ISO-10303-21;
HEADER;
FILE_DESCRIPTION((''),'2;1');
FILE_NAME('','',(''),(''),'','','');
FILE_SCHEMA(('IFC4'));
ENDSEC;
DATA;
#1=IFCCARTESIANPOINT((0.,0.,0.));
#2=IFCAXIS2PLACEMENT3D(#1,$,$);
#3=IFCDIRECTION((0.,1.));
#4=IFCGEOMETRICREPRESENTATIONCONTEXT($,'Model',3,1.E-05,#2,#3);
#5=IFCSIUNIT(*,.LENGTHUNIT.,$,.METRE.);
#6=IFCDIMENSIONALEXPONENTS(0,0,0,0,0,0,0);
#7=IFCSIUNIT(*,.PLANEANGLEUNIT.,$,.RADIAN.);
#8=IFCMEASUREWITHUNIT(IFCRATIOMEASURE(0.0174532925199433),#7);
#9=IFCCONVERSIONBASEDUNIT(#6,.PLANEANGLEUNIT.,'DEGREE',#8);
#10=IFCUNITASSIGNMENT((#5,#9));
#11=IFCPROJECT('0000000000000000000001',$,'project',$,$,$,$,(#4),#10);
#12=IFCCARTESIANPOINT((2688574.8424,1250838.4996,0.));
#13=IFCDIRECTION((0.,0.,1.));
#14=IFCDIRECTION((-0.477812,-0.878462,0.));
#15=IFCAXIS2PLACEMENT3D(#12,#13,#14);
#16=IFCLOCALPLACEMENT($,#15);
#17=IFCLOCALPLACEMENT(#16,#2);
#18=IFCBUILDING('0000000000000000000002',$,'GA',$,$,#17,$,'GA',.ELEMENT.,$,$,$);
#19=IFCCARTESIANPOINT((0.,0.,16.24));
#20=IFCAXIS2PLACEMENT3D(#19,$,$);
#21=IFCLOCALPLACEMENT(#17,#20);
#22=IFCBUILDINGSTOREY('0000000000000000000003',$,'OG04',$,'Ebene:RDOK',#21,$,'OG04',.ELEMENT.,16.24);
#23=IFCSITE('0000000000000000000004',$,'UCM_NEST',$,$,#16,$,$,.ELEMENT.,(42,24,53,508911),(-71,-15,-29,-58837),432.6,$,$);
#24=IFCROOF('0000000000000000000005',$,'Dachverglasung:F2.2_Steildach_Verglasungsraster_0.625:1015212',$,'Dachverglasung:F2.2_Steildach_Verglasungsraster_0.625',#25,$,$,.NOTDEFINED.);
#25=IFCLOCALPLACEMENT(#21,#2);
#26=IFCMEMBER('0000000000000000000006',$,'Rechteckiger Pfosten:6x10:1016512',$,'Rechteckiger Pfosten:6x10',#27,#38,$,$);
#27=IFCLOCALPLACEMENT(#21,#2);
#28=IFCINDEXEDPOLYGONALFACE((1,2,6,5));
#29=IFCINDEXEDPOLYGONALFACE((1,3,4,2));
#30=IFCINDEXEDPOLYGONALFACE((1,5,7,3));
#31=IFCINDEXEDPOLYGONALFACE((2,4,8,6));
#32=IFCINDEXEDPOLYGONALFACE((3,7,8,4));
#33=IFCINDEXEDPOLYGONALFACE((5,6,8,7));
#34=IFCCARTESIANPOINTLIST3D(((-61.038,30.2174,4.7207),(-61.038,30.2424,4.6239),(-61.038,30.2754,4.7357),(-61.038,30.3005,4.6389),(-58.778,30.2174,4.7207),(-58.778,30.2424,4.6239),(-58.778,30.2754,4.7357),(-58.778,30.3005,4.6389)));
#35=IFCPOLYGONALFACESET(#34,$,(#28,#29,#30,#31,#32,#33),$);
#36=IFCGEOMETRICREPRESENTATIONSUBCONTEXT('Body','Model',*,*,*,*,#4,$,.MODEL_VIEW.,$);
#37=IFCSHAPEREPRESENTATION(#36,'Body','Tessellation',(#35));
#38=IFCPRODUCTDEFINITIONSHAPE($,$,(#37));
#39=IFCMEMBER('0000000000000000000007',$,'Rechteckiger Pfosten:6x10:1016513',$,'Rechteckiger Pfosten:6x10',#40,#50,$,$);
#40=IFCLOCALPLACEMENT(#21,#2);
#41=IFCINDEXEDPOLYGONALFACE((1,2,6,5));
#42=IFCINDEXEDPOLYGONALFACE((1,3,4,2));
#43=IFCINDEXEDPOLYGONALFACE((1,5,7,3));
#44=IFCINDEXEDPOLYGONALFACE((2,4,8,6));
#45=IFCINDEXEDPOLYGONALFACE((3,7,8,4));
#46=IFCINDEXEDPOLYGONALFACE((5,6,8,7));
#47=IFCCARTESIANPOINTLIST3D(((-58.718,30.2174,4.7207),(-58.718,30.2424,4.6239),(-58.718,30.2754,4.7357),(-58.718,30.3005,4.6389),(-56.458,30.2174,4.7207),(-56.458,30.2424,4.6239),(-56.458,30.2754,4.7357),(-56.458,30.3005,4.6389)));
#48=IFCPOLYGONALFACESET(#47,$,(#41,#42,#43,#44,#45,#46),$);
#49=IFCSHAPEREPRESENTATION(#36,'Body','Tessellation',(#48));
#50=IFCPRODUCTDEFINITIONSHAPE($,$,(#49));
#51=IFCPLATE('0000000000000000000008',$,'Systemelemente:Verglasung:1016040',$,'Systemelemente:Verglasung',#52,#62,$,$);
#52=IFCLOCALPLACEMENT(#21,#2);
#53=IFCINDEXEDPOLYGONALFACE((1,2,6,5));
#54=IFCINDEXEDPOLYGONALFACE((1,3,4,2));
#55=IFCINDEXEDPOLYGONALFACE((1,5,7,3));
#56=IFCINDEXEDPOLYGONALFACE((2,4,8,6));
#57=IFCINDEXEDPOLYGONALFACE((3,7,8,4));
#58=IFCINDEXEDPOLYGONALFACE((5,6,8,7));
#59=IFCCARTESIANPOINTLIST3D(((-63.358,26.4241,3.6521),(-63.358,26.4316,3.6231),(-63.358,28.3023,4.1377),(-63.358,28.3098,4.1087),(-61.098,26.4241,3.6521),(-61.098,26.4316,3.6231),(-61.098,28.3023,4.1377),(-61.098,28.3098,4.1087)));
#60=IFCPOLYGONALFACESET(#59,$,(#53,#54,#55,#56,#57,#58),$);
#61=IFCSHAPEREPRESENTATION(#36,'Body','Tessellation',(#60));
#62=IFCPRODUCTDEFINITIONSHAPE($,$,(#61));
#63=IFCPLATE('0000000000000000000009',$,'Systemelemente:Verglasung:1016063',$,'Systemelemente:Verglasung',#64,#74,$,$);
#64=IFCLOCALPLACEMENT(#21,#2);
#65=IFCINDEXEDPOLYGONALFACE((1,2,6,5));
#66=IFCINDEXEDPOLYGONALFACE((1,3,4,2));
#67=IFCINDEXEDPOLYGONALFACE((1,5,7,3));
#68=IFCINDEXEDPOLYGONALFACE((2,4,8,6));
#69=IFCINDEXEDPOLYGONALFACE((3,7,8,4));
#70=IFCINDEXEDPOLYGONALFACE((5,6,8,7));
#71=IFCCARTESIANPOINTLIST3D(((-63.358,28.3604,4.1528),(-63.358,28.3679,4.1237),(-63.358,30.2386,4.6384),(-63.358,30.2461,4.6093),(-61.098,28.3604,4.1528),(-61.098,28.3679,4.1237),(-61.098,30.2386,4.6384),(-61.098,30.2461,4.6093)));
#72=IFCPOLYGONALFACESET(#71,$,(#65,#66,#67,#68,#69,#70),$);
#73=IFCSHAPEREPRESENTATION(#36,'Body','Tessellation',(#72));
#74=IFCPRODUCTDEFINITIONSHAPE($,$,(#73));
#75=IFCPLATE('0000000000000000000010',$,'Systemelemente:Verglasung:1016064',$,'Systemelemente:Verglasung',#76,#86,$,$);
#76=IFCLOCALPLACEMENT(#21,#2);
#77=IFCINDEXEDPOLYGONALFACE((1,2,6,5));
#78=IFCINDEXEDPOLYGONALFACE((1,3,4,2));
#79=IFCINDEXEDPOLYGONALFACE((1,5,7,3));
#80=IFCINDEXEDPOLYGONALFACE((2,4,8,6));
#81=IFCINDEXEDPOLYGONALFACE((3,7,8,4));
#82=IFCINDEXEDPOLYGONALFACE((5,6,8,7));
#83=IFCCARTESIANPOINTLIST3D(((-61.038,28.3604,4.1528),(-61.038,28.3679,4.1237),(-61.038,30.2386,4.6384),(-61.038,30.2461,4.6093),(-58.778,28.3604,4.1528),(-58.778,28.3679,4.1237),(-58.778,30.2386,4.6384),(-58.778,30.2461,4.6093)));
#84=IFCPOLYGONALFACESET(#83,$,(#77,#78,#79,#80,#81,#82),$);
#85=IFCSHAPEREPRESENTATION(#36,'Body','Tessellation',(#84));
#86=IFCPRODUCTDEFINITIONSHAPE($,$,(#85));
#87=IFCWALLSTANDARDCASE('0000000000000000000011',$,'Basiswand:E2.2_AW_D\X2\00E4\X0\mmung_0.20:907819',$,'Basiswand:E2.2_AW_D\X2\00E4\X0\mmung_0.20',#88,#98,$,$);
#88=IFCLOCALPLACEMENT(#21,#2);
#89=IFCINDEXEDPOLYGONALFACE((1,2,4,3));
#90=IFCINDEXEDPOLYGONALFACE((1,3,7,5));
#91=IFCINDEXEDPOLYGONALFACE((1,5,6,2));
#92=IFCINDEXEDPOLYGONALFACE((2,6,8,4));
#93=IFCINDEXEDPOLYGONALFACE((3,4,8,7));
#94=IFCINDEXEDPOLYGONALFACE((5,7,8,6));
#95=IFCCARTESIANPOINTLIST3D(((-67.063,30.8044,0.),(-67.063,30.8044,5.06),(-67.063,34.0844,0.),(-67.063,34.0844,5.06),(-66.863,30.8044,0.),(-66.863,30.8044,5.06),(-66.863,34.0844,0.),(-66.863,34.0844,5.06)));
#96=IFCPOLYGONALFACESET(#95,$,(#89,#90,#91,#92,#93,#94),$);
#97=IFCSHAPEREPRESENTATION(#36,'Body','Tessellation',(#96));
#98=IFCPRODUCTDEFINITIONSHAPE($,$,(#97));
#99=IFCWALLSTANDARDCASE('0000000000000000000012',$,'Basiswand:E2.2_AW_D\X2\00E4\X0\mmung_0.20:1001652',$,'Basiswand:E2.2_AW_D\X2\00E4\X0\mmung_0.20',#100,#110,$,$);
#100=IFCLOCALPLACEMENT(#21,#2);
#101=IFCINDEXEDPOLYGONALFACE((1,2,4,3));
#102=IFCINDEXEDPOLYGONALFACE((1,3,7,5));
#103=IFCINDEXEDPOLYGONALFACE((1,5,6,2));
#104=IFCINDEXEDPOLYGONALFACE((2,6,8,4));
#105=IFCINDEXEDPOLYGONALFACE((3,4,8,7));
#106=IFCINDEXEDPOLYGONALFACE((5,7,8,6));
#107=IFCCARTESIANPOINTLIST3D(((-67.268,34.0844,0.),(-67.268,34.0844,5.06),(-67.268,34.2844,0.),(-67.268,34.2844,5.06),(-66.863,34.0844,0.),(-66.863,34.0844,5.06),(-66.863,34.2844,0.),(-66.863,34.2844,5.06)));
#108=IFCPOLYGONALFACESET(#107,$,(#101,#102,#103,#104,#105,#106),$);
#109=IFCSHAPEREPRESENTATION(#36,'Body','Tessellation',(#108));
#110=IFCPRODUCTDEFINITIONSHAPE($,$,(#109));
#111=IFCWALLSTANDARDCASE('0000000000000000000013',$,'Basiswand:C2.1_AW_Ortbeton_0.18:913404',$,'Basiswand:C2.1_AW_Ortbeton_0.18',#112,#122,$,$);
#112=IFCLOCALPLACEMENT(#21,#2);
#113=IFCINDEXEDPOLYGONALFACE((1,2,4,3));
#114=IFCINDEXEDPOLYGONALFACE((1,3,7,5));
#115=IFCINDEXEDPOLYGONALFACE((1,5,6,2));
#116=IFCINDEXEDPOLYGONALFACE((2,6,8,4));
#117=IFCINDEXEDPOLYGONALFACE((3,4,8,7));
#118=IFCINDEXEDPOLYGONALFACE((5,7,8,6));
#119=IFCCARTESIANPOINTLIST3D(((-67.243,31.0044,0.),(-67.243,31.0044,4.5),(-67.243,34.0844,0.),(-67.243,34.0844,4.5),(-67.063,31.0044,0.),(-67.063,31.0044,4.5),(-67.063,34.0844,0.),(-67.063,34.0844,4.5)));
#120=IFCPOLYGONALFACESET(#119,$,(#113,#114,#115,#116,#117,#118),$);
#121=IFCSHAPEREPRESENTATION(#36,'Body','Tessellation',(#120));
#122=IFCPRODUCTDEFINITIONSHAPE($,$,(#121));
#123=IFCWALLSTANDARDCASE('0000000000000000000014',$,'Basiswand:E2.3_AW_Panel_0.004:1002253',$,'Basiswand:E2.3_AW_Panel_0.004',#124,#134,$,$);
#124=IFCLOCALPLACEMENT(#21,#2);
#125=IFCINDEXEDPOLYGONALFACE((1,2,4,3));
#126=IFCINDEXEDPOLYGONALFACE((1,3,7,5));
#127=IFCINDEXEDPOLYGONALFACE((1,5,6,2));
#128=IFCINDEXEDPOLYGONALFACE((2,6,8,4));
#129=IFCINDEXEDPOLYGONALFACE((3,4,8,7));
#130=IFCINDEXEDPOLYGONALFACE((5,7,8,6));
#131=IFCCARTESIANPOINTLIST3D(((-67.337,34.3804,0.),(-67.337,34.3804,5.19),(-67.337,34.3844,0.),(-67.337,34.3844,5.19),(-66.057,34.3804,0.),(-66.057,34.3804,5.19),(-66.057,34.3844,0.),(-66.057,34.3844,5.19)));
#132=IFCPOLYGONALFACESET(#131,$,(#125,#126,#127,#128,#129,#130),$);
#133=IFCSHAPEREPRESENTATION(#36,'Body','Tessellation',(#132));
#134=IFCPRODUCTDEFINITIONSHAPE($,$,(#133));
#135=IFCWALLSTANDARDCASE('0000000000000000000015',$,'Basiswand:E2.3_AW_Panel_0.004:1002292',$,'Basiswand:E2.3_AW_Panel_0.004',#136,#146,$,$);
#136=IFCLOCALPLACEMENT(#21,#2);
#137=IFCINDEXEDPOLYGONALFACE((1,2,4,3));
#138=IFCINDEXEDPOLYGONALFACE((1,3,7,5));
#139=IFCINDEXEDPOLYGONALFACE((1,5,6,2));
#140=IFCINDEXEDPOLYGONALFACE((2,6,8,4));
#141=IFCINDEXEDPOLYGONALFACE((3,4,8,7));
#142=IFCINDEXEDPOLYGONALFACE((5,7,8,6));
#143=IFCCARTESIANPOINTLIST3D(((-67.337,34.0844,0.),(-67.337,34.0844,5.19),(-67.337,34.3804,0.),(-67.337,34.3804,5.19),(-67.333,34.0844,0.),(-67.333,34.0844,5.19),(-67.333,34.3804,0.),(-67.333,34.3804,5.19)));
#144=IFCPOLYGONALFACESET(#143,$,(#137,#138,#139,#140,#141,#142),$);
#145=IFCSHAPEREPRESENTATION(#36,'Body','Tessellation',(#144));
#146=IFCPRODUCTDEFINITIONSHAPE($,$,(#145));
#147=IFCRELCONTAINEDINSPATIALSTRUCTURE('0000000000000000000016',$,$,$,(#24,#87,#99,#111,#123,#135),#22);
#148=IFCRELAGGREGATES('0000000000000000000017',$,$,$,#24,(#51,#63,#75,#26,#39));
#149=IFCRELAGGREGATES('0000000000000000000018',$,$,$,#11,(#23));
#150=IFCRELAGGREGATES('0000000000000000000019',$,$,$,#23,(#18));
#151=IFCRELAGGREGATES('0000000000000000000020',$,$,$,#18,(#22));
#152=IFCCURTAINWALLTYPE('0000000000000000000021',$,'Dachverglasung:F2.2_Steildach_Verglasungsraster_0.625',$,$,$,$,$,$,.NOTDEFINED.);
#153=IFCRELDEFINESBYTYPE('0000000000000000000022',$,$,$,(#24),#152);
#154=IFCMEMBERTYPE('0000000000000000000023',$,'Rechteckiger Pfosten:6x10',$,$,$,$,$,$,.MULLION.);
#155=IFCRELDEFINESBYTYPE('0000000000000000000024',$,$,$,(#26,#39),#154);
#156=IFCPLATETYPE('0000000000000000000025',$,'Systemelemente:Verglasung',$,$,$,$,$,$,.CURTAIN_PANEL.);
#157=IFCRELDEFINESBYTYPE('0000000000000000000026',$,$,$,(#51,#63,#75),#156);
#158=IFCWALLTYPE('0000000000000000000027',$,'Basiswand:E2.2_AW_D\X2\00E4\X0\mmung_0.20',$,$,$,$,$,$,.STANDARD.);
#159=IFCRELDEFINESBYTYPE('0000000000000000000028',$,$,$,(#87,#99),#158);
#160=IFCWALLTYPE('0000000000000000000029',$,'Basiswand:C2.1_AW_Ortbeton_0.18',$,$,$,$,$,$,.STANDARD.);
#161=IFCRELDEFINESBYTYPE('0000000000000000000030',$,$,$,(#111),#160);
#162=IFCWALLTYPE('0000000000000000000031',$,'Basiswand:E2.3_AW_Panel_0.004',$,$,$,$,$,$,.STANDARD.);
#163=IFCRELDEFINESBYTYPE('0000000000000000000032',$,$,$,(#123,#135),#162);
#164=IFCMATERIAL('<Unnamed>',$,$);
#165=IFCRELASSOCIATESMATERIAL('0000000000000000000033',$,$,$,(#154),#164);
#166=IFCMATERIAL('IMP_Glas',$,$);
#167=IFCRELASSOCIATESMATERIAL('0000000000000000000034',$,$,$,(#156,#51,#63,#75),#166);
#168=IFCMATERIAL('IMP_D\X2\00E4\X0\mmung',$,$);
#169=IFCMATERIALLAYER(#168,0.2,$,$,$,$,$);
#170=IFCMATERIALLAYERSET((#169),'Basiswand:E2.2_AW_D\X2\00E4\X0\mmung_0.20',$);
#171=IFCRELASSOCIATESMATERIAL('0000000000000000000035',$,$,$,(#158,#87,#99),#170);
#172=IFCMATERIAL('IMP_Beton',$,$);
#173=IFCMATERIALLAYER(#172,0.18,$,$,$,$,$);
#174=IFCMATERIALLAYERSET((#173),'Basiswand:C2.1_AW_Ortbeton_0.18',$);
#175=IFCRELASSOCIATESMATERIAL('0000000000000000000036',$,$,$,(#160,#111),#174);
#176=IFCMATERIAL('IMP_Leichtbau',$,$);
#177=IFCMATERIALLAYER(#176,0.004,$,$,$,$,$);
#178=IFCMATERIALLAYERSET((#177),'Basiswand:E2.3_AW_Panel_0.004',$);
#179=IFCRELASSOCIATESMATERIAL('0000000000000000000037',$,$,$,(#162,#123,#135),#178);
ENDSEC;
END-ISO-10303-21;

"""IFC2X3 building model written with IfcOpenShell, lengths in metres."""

from ifc_helpers import new_model, entity, si_unit, converted_unit, direction, frame, frame_2d, origin, origin_2d_with_axis, place, context, subcontext, project, spatial, rectangle, extrude, source, transform, mapped, material, layer, layer_set, layer_usage, type_object, type_shapes, element, aggregate, save


model = new_model("IFC2X3")

# Units and contexts
model_context = context("Model", 3, precision=1e-05, world=origin(), true_north=direction((0.0, 1.0)))
body_context = subcontext(model_context, "Body", "Model", "MODEL_VIEW")
ifc_project = project(units=[si_unit("LENGTHUNIT", "METRE"), converted_unit("PLANEANGLEUNIT", "DEGREE", entity("IfcRatioMeasure", 0.0174532925199433), si_unit("PLANEANGLEUNIT", "RADIAN"), dimensions=[0, 0, 0, 0, 0, 0, 0])], contexts=[model_context])

# Site, building, storey
site_placement = place(None, frame((2688574.8424, 1250838.4996, 0.0), z_axis=(0.0, 0.0, 1.0), x_axis=(-0.477812, -0.878462, 0.0)))
site = spatial("IfcSite", under=ifc_project, at=site_placement, Name="UCM_NEST", CompositionType="ELEMENT", RefLatitude=(42, 24, 53, 508911), RefLongitude=(-71, -15, -29, -58837), RefElevation=432.6)
building_placement = place(site_placement, origin())
building = spatial("IfcBuilding", under=site, at=building_placement, Name="GA", LongName="GA", CompositionType="ELEMENT")
storey_placement = place(building_placement, frame((0.0, 0.0, 16.24)))
storey = spatial("IfcBuildingStorey", under=building, at=storey_placement, Name="OG04", ObjectType="Ebene:RDOK", LongName="OG04", CompositionType="ELEMENT", Elevation=16.24)

# Roof, members, plates
curtain_wall_type = type_object("IfcCurtainWallType", Name="Dachverglasung:F2.2_Steildach_Verglasungsraster_0.625", PredefinedType="NOTDEFINED")
roof_placement = place(storey_placement, frame((0.0, 0.0, -16.24)))
roof = element("IfcRoof", 1, at=roof_placement, inside=storey, type_object=curtain_wall_type, Name="Dachverglasung:F2.2_Steildach_Verglasungsraster_0.625:1015212", ObjectType="Dachverglasung:F2.2_Steildach_Verglasungsraster_0.625", ShapeType="NOTDEFINED")
ifc_material_1 = material(Name="<Unnamed>")
member_type_1 = type_object("IfcMemberType", Name="Rechteckiger Pfosten:6x10", PredefinedType="MULLION", material=ifc_material_1)
shared_shape_1 = source(origin(), body_context, "Body", "SweptSolid", [
    extrude(rectangle(XDim=0.1, YDim=0.06, at=origin_2d_with_axis()), frame((-0.03, -0.05, -2.26), z_axis=(0.0, 0.0, 1.0), x_axis=(0.0, -1.0, 0.0)), (0.0, 0.0, 1.0), 2.26),
])
type_shapes(member_type_1, [shared_shape_1])
member_1_placement = place(roof_placement, frame((-61.038, 30.3005, 20.8789), z_axis=(-1.0, 0.0, 0.0), x_axis=(0.0, 0.968163, 0.250322)))
member_1 = element("IfcMember", 2, at=member_1_placement, type_object=member_type_1, Name="Rechteckiger Pfosten:6x10:1016512", ObjectType="Rechteckiger Pfosten:6x10", context=body_context, shape_type="MappedRepresentation", body=[
    mapped(shared_shape_1, transform((0.0, 0.0, 0.0), scale=1.0)),
])
member_2_placement = place(roof_placement, frame((-58.718, 30.3005, 20.8789), z_axis=(-1.0, 0.0, 0.0), x_axis=(0.0, 0.968163, 0.250322)))
member_2 = element("IfcMember", 3, at=member_2_placement, type_object=member_type_1, Name="Rechteckiger Pfosten:6x10:1016513", ObjectType="Rechteckiger Pfosten:6x10", context=body_context, shape_type="MappedRepresentation", body=[
    mapped(shared_shape_1, transform((0.0, 0.0, 0.0), scale=1.0)),
])
ifc_material_2 = material(Name="IMP_Glas")
plate_type = type_object("IfcPlateType", Name="Systemelemente:Verglasung", PredefinedType="CURTAIN_PANEL", material=ifc_material_2)
shared_shape_2 = source(origin(), body_context, "Body", "SweptSolid", [
    extrude(rectangle(XDim=0.03, YDim=2.26, at=origin_2d_with_axis()), frame((0.0, 0.0, 0.0), z_axis=(0.0, 0.0, 1.0), x_axis=(0.0, 1.0, 0.0)), (0.0, 0.0, 1.0), 1.94),
])
type_shapes(plate_type, [shared_shape_2])
plate_1_placement = place(roof_placement, frame((-62.228, 26.4278, 19.8776), z_axis=(0.0, 0.968163, 0.250322), x_axis=(1.0, 0.0, 0.0)))
plate_1 = element("IfcPlate", 4, at=plate_1_placement, type_object=plate_type, material=ifc_material_2, Name="Systemelemente:Verglasung:1016040", ObjectType="Systemelemente:Verglasung", context=body_context, shape_type="MappedRepresentation", body=[
    mapped(shared_shape_2, transform((0.0, 0.0, 0.0), scale=1.0)),
])
plate_2_placement = place(roof_placement, frame((-62.228, 28.3642, 20.3782), z_axis=(0.0, 0.968163, 0.250322), x_axis=(1.0, 0.0, 0.0)))
plate_2 = element("IfcPlate", 5, at=plate_2_placement, type_object=plate_type, material=ifc_material_2, Name="Systemelemente:Verglasung:1016063", ObjectType="Systemelemente:Verglasung", context=body_context, shape_type="MappedRepresentation", body=[
    mapped(shared_shape_2, transform((0.0, 0.0, 0.0), scale=1.0)),
])
plate_3_placement = place(roof_placement, frame((-59.908, 28.3642, 20.3782), z_axis=(0.0, 0.968163, 0.250322), x_axis=(1.0, 0.0, 0.0)))
plate_3 = element("IfcPlate", 6, at=plate_3_placement, type_object=plate_type, material=ifc_material_2, Name="Systemelemente:Verglasung:1016064", ObjectType="Systemelemente:Verglasung", context=body_context, shape_type="MappedRepresentation", body=[
    mapped(shared_shape_2, transform((0.0, 0.0, 0.0), scale=1.0)),
])
aggregate(roof, [plate_1, plate_2, plate_3, member_1, member_2])

# Walls
ifc_material_3 = material(Name="IMP_Dämmung")
ifc_layer_1 = layer(ifc_material_3, 0.2)
ifc_layer_set_1 = layer_set([ifc_layer_1], Name="Basiswand:E2.2_AW_Dämmung_0.20")
ifc_layer_usage_1 = layer_usage(ifc_layer_set_1, "AXIS2", "NEGATIVE", 0.1)
wall_type_1 = type_object("IfcWallType", Name="Basiswand:E2.2_AW_Dämmung_0.20", PredefinedType="STANDARD", material=ifc_layer_set_1)
wall_1_placement = place(storey_placement, frame((-66.963, 34.0844, 0.0), z_axis=(0.0, 0.0, 1.0), x_axis=(0.0, -1.0, 0.0)))
element("IfcWallStandardCase", 7, at=wall_1_placement, inside=storey, type_object=wall_type_1, material=ifc_layer_usage_1, Name="Basiswand:E2.2_AW_Dämmung_0.20:907819", ObjectType="Basiswand:E2.2_AW_Dämmung_0.20", context=body_context, shape_type="SweptSolid", body=[
    extrude(rectangle(XDim=3.28, YDim=0.2, at=frame_2d((1.64, 0.0), x_axis=(-1.0, 0.0))), origin(), (0.0, 0.0, 1.0), 5.06),
])
ifc_layer_usage_2 = layer_usage(ifc_layer_set_1, "AXIS2", "POSITIVE", -0.1)
wall_2_placement = place(storey_placement, frame((-66.863, 34.1844, 0.0), z_axis=(0.0, 0.0, 1.0), x_axis=(-1.0, 0.0, 0.0)))
element("IfcWallStandardCase", 8, at=wall_2_placement, inside=storey, type_object=wall_type_1, material=ifc_layer_usage_2, Name="Basiswand:E2.2_AW_Dämmung_0.20:1001652", ObjectType="Basiswand:E2.2_AW_Dämmung_0.20", context=body_context, shape_type="SweptSolid", body=[
    extrude(rectangle(XDim=0.405, YDim=0.2, at=frame_2d((0.2025, 0.0), x_axis=(-1.0, 0.0))), origin(), (0.0, 0.0, 1.0), 5.06),
])
ifc_material_4 = material(Name="IMP_Beton")
ifc_layer_2 = layer(ifc_material_4, 0.18)
ifc_layer_set_2 = layer_set([ifc_layer_2], Name="Basiswand:C2.1_AW_Ortbeton_0.18")
ifc_layer_usage_3 = layer_usage(ifc_layer_set_2, "AXIS2", "NEGATIVE", 0.09)
wall_type_2 = type_object("IfcWallType", Name="Basiswand:C2.1_AW_Ortbeton_0.18", PredefinedType="STANDARD", material=ifc_layer_set_2)
wall_3_placement = place(storey_placement, frame((-67.153, 34.0844, 0.0), z_axis=(0.0, 0.0, 1.0), x_axis=(0.0, -1.0, 0.0)))
element("IfcWallStandardCase", 9, at=wall_3_placement, inside=storey, type_object=wall_type_2, material=ifc_layer_usage_3, Name="Basiswand:C2.1_AW_Ortbeton_0.18:913404", ObjectType="Basiswand:C2.1_AW_Ortbeton_0.18", context=body_context, shape_type="SweptSolid", body=[
    extrude(rectangle(XDim=3.08, YDim=0.18, at=frame_2d((1.54, 0.0), x_axis=(-1.0, 0.0))), origin(), (0.0, 0.0, 1.0), 4.5),
])
ifc_material_5 = material(Name="IMP_Leichtbau")
ifc_layer_3 = layer(ifc_material_5, 0.004)
ifc_layer_set_3 = layer_set([ifc_layer_3], Name="Basiswand:E2.3_AW_Panel_0.004")
ifc_layer_usage_4 = layer_usage(ifc_layer_set_3, "AXIS2", "NEGATIVE", 0.002)
wall_type_3 = type_object("IfcWallType", Name="Basiswand:E2.3_AW_Panel_0.004", PredefinedType="STANDARD", material=ifc_layer_set_3)
wall_4_placement = place(storey_placement, frame((-66.057, 34.3824, 0.0), z_axis=(0.0, 0.0, 1.0), x_axis=(-1.0, 0.0, 0.0)))
element("IfcWallStandardCase", 10, at=wall_4_placement, inside=storey, type_object=wall_type_3, material=ifc_layer_usage_4, Name="Basiswand:E2.3_AW_Panel_0.004:1002253", ObjectType="Basiswand:E2.3_AW_Panel_0.004", context=body_context, shape_type="SweptSolid", body=[
    extrude(rectangle(XDim=1.28, YDim=0.004, at=frame_2d((0.64, 0.0), x_axis=(-1.0, 0.0))), origin(), (0.0, 0.0, 1.0), 5.19),
])
ifc_layer_usage_5 = layer_usage(ifc_layer_set_3, "AXIS2", "NEGATIVE", 0.002)
wall_5_placement = place(storey_placement, frame((-67.335, 34.3804, 0.0), z_axis=(0.0, 0.0, 1.0), x_axis=(0.0, -1.0, 0.0)))
element("IfcWallStandardCase", 11, at=wall_5_placement, inside=storey, type_object=wall_type_3, material=ifc_layer_usage_5, Name="Basiswand:E2.3_AW_Panel_0.004:1002292", ObjectType="Basiswand:E2.3_AW_Panel_0.004", context=body_context, shape_type="SweptSolid", body=[
    extrude(rectangle(XDim=0.296, YDim=0.004, at=frame_2d((0.148, 0.0), x_axis=(-1.0, 0.0))), origin(), (0.0, 0.0, 1.0), 5.19),
])

save(model, "model.ifc")
